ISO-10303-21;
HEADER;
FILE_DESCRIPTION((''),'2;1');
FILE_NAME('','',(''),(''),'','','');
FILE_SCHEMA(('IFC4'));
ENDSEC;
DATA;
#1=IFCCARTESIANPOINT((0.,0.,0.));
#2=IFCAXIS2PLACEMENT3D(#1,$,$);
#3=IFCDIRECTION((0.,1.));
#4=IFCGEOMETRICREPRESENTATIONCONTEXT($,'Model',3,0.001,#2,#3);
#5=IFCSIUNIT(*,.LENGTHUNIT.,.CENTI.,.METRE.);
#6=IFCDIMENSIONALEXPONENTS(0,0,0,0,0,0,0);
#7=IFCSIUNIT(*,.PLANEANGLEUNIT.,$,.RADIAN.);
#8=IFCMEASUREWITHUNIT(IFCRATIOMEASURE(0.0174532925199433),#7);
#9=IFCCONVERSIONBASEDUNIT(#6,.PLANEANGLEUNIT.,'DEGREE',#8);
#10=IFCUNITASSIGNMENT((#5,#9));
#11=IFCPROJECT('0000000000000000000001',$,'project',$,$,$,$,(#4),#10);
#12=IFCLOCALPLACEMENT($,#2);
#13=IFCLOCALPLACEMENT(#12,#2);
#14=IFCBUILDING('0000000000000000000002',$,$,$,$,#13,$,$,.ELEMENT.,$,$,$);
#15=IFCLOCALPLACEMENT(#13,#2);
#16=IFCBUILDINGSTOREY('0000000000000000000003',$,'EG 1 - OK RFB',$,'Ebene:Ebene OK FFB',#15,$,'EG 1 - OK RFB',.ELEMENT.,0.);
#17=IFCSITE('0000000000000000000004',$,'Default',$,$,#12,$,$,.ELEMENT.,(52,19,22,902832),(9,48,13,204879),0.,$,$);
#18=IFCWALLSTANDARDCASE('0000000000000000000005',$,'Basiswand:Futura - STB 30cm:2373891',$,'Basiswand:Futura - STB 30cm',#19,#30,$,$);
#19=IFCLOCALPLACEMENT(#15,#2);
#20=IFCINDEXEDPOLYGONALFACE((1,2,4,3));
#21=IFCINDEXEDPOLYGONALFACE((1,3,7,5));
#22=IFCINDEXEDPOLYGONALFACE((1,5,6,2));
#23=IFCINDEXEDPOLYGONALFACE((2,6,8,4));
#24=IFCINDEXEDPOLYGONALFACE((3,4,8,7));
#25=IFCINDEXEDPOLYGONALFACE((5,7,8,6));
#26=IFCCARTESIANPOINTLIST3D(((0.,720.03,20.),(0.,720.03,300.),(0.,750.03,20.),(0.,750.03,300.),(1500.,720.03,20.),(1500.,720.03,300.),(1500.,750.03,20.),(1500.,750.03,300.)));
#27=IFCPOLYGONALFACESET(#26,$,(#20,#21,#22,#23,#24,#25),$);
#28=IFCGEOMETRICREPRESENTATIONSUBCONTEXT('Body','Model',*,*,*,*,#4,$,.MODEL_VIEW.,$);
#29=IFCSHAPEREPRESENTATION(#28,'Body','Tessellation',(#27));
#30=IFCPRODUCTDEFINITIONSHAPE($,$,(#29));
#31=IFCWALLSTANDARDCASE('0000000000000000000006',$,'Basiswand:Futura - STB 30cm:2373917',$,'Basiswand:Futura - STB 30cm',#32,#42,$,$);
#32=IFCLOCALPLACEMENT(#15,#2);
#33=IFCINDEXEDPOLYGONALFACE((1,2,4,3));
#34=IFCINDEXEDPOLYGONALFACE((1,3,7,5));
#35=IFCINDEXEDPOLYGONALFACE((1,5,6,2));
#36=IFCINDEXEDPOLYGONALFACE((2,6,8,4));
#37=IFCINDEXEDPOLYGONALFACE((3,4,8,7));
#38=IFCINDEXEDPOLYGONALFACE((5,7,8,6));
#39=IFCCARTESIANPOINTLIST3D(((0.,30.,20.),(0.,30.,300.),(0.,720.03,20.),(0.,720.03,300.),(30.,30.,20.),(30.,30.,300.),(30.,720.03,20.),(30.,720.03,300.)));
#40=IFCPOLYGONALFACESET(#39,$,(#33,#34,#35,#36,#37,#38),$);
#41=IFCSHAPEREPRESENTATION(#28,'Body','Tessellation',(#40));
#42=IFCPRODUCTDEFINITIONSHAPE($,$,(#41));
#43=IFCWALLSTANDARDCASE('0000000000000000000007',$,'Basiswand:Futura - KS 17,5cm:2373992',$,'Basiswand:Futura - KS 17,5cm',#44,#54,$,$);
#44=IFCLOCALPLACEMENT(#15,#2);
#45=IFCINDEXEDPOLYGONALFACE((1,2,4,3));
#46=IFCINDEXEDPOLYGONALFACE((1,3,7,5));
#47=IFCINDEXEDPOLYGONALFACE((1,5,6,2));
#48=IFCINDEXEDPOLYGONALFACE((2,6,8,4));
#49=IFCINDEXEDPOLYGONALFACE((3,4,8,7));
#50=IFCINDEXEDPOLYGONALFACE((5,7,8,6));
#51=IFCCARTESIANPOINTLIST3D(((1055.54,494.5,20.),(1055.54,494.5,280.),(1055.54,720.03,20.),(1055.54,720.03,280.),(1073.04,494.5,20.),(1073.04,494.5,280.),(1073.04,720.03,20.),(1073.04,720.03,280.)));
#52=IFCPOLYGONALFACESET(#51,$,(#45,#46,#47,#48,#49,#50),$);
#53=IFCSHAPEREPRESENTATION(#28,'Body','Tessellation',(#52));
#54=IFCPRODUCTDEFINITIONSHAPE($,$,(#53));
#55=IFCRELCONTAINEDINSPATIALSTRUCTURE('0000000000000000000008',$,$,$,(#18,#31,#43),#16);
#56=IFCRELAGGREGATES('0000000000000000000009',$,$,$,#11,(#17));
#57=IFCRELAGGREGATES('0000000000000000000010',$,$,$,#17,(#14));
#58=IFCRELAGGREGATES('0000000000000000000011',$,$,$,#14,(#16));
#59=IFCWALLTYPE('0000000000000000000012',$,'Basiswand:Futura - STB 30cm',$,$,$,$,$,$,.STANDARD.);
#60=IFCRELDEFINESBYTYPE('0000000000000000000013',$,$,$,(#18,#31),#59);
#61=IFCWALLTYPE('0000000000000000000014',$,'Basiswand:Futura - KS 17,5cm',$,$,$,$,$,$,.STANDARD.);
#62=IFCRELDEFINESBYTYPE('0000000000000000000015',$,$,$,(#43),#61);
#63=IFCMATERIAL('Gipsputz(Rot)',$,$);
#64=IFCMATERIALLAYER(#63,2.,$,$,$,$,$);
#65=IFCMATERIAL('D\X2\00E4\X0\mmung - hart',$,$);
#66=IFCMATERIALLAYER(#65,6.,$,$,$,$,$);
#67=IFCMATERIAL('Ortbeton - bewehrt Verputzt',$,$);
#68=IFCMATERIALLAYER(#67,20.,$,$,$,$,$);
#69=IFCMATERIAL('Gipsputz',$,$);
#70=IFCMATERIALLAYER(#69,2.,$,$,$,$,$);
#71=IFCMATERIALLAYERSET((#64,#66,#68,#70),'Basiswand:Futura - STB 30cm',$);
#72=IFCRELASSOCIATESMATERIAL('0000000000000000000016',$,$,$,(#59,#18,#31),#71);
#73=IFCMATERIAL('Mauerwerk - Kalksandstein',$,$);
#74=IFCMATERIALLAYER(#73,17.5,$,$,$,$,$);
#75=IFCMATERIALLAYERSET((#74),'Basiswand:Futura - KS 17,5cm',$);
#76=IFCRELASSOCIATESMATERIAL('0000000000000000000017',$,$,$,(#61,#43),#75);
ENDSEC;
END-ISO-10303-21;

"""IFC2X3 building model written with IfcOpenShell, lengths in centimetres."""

from ifc_helpers import new_model, entity, si_unit, converted_unit, direction, frame, frame_2d, origin, place, context, subcontext, project, spatial, polyline, rectangle, extrude, clip, bounded_halfspace, material, layer, layer_set, layer_usage, type_object, element, save


model = new_model("IFC2X3")

# Units and contexts
model_context = context("Model", 3, precision=0.001, world=origin(), true_north=direction((0.0, 1.0)))
body_context = subcontext(model_context, "Body", "Model", "MODEL_VIEW")
ifc_project = project(units=[si_unit("LENGTHUNIT", "METRE", prefix="CENTI"), converted_unit("PLANEANGLEUNIT", "DEGREE", entity("IfcRatioMeasure", 0.0174532925199433), si_unit("PLANEANGLEUNIT", "RADIAN"), dimensions=[0, 0, 0, 0, 0, 0, 0])], contexts=[model_context])

# Site, building, storey
site_placement = place(None, frame((0.0, 0.0, 0.0)))
site = spatial("IfcSite", under=ifc_project, at=site_placement, Name="Default", CompositionType="ELEMENT", RefLatitude=(52, 19, 22, 902832), RefLongitude=(9, 48, 13, 204879), RefElevation=0.0)
building_placement = place(site_placement, origin())
building = spatial("IfcBuilding", under=site, at=building_placement, CompositionType="ELEMENT")
storey_placement = place(building_placement, origin())
storey = spatial("IfcBuildingStorey", under=building, at=storey_placement, Name="EG 1 - OK RFB", ObjectType="Ebene:Ebene OK FFB", LongName="EG 1 - OK RFB", CompositionType="ELEMENT", Elevation=0.0)

# Walls
ifc_material_1 = material(Name="Gipsputz(Rot)")
ifc_layer_1 = layer(ifc_material_1, 2.0)
ifc_material_2 = material(Name="Dämmung - hart")
ifc_layer_2 = layer(ifc_material_2, 6.0)
ifc_material_3 = material(Name="Ortbeton - bewehrt Verputzt")
ifc_layer_3 = layer(ifc_material_3, 20.0)
ifc_material_4 = material(Name="Gipsputz")
ifc_layer_4 = layer(ifc_material_4, 2.0)
ifc_layer_set_1 = layer_set([ifc_layer_1, ifc_layer_2, ifc_layer_3, ifc_layer_4], Name="Basiswand:Futura - STB 30cm")
ifc_layer_usage_1 = layer_usage(ifc_layer_set_1, "AXIS2", "NEGATIVE", 15.0)
wall_type_1 = type_object("IfcWallType", Name="Basiswand:Futura - STB 30cm", PredefinedType="STANDARD", material=ifc_layer_set_1)
wall_1_placement = place(storey_placement, frame((0.0, 735.03, 20.0)))
element("IfcWallStandardCase", 1, at=wall_1_placement, inside=storey, type_object=wall_type_1, material=ifc_layer_usage_1, Name="Basiswand:Futura - STB 30cm:2373891", ObjectType="Basiswand:Futura - STB 30cm", context=body_context, shape_type="Clipping", body=[
    clip(extrude(rectangle(XDim=1500.0, YDim=30.0, at=frame_2d((750.0, 0.0), x_axis=(-1.0, 0.0))), origin(), (0.0, 0.0, 1.0), 280.0), bounded_halfspace(frame((1500.0, -15.0, 0.0), z_axis=(0.0, 0.0, 1.0), x_axis=(0.0, 1.0, 0.0)), True, frame((1500.0, -15.0, 0.0), z_axis=(0.0, 0.0, 1.0), x_axis=(0.0, 1.0, 0.0)), polyline([(0.0, 0.0), (30.0, 0.0), (30.0, 1500.0), (0.0, 1500.0), (0.0, 1470.0), (0.0, 444.46), (0.0, 426.96), (0.0, 30.0), (0.0, 0.0)]))),
])
ifc_layer_usage_2 = layer_usage(ifc_layer_set_1, "AXIS2", "POSITIVE", -15.0)
wall_2_placement = place(storey_placement, frame((15.0, 720.03, 20.0), z_axis=(0.0, 0.0, 1.0), x_axis=(0.0, -1.0, 0.0)))
element("IfcWallStandardCase", 2, at=wall_2_placement, inside=storey, type_object=wall_type_1, material=ifc_layer_usage_2, Name="Basiswand:Futura - STB 30cm:2373917", ObjectType="Basiswand:Futura - STB 30cm", context=body_context, shape_type="Clipping", body=[
    clip(extrude(rectangle(XDim=690.03, YDim=30.0, at=frame_2d((345.02, 0.0), x_axis=(-1.0, 0.0))), origin(), (0.0, 0.0, 1.0), 280.0), bounded_halfspace(frame((690.03, -15.0, 0.0), z_axis=(0.0, 0.0, 1.0), x_axis=(-1.0, 0.0, 0.0)), True, frame((690.03, -15.0, 0.0), z_axis=(0.0, 0.0, 1.0), x_axis=(-1.0, 0.0, 0.0)), polyline([(0.0, 0.0), (0.0, -30.0), (690.03, -30.0), (690.03, 0.0), (0.0, 0.0)]))),
])
ifc_material_5 = material(Name="Mauerwerk - Kalksandstein")
ifc_layer_5 = layer(ifc_material_5, 17.5)
ifc_layer_set_2 = layer_set([ifc_layer_5], Name="Basiswand:Futura - KS 17,5cm")
ifc_layer_usage_3 = layer_usage(ifc_layer_set_2, "AXIS2", "NEGATIVE", 8.75)
wall_type_2 = type_object("IfcWallType", Name="Basiswand:Futura - KS 17,5cm", PredefinedType="STANDARD", material=ifc_layer_set_2)
wall_3_placement = place(storey_placement, frame((1064.29, 720.03, 20.0), z_axis=(0.0, 0.0, 1.0), x_axis=(0.0, -1.0, 0.0)))
element("IfcWallStandardCase", 3, at=wall_3_placement, inside=storey, type_object=wall_type_2, material=ifc_layer_usage_3, Name="Basiswand:Futura - KS 17,5cm:2373992", ObjectType="Basiswand:Futura - KS 17,5cm", context=body_context, shape_type="Clipping", body=[
    clip(extrude(rectangle(XDim=225.54, YDim=17.5, at=frame_2d((112.77, 0.0), x_axis=(-1.0, 0.0))), origin(), (0.0, 0.0, 1.0), 260.0), bounded_halfspace(frame((225.54, -8.75, 0.0), z_axis=(0.0, 0.0, 1.0), x_axis=(-1.0, 0.0, 0.0)), True, frame((225.54, -8.75, 0.0), z_axis=(0.0, 0.0, 1.0), x_axis=(-1.0, 0.0, 0.0)), polyline([(0.0, 0.0), (0.0, -17.5), (225.54, -17.5), (225.54, 0.0), (0.0, 0.0)]))),
])

save(model, "model.ifc")
